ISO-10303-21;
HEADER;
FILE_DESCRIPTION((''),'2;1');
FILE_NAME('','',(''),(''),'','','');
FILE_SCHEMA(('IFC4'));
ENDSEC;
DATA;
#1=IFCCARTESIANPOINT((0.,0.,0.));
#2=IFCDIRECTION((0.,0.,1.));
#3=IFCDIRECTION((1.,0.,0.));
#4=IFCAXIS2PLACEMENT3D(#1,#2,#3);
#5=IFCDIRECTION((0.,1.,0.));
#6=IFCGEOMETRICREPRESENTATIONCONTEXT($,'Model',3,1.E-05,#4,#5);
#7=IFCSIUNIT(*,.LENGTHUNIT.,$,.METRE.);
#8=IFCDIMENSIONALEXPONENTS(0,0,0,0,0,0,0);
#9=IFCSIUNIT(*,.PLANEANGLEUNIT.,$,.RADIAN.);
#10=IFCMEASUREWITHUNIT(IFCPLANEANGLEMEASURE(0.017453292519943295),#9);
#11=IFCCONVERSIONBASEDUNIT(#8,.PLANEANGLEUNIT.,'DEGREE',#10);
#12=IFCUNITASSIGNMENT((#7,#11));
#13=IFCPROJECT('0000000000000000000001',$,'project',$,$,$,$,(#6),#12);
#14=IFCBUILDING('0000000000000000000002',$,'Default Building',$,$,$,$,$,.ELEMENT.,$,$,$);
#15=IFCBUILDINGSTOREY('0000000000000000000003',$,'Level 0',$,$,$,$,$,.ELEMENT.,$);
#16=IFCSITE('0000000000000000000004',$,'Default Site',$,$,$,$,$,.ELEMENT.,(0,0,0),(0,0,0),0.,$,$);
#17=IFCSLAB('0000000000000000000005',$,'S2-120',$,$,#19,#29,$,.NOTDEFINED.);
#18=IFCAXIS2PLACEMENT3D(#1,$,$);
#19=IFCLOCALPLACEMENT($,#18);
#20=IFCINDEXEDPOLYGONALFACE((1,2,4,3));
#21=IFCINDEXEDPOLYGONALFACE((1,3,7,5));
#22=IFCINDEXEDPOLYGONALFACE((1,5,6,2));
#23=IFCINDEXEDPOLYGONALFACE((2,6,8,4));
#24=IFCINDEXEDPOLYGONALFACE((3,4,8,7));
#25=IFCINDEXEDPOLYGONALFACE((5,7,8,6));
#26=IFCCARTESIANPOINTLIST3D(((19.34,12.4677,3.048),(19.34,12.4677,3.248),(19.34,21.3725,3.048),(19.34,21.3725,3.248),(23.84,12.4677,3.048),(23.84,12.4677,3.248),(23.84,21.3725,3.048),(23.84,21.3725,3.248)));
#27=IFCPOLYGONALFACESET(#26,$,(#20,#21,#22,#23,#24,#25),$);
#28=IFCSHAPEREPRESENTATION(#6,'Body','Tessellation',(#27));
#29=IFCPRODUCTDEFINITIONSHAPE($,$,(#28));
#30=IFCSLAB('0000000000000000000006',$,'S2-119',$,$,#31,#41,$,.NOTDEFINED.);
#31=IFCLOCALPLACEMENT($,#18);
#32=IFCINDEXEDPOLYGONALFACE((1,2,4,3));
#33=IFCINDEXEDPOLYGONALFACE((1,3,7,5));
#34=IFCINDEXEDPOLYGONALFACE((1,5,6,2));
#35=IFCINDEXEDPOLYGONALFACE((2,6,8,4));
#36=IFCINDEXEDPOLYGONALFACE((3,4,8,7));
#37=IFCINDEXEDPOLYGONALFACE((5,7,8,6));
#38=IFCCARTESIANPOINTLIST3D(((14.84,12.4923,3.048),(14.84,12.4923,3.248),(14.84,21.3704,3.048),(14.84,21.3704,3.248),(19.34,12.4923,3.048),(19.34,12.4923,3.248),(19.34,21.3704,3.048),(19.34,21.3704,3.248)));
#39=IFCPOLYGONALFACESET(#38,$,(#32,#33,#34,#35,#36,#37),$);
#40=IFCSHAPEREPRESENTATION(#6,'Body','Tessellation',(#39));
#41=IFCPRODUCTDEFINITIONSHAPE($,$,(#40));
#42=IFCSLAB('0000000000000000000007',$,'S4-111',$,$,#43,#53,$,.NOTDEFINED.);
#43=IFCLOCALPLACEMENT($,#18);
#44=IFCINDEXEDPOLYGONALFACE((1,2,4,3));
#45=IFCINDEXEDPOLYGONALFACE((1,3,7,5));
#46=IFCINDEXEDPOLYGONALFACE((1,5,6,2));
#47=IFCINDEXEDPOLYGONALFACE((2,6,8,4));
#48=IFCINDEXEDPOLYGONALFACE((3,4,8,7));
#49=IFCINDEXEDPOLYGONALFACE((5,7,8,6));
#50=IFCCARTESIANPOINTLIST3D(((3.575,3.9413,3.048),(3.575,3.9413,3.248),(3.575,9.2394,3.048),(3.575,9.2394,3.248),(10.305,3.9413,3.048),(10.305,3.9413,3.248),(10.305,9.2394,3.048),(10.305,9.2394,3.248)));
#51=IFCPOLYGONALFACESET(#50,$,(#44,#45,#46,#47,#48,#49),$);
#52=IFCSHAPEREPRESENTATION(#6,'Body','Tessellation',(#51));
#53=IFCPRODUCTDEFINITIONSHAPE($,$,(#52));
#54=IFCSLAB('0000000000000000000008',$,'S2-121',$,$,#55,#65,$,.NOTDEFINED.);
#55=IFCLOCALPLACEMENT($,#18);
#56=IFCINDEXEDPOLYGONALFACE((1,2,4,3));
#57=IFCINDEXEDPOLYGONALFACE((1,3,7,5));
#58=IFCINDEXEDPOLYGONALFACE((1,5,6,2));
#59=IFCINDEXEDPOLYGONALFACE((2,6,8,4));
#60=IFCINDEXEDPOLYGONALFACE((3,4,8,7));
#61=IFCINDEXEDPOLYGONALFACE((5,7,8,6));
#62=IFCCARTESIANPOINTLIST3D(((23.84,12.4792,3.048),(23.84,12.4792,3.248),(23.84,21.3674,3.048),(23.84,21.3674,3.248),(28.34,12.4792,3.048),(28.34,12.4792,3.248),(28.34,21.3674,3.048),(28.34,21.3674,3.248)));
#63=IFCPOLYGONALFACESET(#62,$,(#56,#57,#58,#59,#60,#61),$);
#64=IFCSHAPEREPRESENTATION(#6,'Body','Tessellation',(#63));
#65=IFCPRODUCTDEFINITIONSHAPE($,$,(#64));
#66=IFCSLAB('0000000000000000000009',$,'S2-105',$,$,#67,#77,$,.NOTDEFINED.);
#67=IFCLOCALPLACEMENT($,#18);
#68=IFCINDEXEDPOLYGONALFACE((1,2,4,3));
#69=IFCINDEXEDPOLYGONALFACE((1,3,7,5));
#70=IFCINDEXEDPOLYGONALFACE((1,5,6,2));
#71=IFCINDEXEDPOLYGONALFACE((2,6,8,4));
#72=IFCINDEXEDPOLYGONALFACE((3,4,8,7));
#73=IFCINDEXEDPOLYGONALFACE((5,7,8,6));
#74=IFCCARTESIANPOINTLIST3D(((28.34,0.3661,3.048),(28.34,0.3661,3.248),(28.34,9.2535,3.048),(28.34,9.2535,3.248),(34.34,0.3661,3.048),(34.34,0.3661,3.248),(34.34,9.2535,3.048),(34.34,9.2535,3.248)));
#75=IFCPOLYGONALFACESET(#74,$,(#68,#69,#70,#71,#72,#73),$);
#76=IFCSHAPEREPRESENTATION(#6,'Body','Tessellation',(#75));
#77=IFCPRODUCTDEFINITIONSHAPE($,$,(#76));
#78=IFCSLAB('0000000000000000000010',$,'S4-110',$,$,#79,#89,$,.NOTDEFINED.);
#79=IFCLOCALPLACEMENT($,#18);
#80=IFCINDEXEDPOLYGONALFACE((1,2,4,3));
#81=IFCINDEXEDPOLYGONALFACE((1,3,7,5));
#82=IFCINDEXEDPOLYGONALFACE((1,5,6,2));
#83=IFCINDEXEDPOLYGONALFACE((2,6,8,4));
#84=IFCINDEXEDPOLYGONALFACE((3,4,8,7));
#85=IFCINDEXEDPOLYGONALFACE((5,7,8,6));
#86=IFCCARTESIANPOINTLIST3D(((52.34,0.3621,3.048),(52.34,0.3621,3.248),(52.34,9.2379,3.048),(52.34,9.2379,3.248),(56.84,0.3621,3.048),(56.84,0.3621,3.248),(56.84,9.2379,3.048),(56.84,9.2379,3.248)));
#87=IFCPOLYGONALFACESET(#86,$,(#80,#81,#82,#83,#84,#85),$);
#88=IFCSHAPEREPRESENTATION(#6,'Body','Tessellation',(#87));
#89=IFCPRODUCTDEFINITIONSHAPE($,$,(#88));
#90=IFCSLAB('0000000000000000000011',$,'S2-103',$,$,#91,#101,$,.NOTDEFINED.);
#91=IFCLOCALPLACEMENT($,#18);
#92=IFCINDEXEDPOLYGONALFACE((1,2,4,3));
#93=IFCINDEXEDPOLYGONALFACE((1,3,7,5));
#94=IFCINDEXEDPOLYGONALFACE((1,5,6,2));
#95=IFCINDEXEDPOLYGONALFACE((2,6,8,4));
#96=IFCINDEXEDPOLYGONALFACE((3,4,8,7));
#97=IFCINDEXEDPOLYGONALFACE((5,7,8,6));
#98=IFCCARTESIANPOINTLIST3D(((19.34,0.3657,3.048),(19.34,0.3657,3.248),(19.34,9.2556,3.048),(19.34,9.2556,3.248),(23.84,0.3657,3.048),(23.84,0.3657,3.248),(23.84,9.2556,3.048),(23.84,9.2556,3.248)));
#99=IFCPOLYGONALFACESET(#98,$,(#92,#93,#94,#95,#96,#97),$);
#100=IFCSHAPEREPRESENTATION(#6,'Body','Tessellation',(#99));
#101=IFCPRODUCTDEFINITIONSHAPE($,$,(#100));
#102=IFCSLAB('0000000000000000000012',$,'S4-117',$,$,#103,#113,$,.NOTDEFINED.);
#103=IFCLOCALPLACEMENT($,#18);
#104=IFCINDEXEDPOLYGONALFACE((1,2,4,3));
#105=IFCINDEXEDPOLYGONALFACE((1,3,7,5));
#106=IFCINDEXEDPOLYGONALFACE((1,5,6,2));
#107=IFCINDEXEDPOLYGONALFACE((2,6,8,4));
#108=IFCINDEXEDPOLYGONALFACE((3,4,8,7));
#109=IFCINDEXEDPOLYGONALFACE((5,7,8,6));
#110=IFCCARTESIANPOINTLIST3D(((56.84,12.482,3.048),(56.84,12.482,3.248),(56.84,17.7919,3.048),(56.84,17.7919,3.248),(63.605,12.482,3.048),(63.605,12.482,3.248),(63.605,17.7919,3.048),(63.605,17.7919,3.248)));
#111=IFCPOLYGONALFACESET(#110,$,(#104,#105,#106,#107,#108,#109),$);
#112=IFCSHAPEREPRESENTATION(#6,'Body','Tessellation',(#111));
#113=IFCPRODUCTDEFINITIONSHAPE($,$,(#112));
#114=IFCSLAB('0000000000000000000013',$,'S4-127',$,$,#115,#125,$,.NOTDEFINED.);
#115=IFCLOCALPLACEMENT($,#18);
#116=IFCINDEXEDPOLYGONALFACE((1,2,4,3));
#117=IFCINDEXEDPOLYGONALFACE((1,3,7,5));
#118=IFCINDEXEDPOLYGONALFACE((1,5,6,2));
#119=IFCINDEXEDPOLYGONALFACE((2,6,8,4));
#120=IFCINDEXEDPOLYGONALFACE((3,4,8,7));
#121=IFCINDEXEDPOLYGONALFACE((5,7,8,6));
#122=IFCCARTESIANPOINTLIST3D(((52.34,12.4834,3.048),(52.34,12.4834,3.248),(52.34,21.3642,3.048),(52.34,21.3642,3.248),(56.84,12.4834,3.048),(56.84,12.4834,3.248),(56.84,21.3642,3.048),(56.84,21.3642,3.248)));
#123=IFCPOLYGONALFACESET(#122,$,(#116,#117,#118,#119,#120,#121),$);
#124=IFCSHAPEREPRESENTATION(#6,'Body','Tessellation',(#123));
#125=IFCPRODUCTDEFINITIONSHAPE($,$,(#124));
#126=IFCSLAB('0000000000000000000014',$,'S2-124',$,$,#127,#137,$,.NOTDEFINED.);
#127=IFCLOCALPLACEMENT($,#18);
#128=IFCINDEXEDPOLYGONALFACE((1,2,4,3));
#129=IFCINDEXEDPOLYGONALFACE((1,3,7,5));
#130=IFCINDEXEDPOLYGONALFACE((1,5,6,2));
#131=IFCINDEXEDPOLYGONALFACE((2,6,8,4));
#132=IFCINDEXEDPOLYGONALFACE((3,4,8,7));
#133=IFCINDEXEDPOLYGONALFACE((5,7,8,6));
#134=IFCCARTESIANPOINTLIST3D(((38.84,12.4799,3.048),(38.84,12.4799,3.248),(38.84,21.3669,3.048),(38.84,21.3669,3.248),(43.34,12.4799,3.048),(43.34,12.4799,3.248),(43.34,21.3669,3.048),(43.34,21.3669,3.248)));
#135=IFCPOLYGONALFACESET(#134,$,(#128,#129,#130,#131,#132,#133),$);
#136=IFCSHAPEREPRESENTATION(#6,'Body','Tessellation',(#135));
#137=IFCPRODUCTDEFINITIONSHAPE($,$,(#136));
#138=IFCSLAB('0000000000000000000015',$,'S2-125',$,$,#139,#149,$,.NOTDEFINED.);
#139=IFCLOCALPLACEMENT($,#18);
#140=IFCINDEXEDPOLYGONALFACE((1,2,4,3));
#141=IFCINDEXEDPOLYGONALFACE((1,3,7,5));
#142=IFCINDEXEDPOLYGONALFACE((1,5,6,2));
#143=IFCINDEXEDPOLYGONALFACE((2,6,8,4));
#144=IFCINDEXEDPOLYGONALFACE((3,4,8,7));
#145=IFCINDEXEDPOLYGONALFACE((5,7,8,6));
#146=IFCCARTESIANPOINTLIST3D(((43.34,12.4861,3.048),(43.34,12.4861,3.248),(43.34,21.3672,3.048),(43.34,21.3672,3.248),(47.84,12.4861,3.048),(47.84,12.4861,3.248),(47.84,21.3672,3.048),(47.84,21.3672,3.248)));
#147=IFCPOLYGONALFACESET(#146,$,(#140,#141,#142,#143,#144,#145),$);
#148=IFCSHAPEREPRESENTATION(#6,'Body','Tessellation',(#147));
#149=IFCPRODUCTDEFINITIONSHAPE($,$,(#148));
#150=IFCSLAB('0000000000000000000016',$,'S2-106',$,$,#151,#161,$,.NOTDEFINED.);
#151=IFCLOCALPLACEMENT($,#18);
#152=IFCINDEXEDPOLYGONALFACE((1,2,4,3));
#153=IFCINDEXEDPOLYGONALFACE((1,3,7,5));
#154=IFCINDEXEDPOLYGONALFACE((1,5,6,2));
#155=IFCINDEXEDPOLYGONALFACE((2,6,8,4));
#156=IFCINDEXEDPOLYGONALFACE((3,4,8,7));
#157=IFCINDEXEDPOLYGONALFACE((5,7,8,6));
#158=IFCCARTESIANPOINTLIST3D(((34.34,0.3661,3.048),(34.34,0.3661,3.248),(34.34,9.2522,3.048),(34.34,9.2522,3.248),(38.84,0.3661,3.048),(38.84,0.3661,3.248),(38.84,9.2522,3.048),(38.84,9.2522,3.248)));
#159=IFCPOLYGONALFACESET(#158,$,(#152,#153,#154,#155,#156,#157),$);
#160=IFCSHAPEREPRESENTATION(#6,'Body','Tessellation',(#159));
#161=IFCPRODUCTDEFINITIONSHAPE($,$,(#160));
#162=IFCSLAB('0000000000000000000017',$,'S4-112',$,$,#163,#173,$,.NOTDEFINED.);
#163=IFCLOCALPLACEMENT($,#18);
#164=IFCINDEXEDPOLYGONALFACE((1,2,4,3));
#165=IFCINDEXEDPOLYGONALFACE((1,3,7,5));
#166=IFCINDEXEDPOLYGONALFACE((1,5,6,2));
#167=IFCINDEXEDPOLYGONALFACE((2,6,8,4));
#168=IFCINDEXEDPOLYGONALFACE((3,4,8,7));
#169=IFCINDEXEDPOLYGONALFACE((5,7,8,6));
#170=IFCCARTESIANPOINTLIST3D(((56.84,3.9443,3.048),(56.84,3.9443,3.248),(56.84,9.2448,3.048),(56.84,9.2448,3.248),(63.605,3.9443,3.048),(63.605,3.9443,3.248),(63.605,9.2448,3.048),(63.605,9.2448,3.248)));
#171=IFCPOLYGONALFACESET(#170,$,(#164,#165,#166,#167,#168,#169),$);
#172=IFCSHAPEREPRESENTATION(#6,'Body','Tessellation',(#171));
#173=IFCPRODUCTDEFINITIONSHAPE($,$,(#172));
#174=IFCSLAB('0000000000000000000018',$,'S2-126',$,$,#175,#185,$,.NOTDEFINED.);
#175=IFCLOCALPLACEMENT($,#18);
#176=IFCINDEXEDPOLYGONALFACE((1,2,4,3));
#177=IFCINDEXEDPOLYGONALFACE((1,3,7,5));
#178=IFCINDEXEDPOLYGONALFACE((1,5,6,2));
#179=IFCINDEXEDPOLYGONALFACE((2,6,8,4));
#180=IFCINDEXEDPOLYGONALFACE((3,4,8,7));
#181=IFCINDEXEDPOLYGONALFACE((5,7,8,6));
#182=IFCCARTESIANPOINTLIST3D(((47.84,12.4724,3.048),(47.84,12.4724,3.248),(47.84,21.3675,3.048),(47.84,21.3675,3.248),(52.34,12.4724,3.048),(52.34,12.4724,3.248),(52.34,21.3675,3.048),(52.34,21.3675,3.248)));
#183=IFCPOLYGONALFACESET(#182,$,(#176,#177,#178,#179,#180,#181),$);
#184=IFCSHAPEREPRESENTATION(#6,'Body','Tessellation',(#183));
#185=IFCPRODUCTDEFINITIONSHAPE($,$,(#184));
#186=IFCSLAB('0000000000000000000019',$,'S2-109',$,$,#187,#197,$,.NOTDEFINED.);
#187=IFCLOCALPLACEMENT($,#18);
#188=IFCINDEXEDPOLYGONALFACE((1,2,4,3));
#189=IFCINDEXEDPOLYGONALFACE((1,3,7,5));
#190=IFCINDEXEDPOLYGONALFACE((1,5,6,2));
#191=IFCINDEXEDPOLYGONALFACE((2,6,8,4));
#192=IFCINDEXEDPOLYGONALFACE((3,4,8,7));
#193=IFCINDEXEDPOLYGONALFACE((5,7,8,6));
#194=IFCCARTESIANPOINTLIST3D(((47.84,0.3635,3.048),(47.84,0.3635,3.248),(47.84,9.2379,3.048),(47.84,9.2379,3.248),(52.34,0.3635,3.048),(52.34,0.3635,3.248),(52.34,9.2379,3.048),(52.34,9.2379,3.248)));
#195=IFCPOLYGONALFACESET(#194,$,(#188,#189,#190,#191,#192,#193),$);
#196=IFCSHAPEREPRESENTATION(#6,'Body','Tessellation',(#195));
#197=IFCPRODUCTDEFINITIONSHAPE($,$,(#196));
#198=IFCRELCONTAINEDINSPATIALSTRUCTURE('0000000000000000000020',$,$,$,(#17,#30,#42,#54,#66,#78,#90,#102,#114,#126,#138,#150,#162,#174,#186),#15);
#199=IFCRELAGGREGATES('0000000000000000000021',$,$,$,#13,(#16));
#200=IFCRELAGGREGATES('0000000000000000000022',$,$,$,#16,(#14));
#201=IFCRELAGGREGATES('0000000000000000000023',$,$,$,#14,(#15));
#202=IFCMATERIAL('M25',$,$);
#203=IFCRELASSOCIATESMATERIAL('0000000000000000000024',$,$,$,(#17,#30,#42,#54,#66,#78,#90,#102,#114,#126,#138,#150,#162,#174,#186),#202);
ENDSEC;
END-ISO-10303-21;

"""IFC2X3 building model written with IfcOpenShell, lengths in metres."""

from ifc_helpers import new_model, entity, si_unit, converted_unit, direction, frame, frame_2d, origin_with_axes, place, context, project, spatial, rectangle, extrude, material, element, save


model = new_model("IFC2X3")

# Units and contexts
model_context = context("Model", 3, precision=1e-05, world=origin_with_axes(), true_north=direction((0.0, 1.0, 0.0)))
ifc_project = project(units=[si_unit("LENGTHUNIT", "METRE"), converted_unit("PLANEANGLEUNIT", "DEGREE", entity("IfcPlaneAngleMeasure", 0.017453292519943295), si_unit("PLANEANGLEUNIT", "RADIAN"), dimensions=[0, 0, 0, 0, 0, 0, 0])], contexts=[model_context])

# Site, building, storey
site = spatial("IfcSite", under=ifc_project, Name="Default Site", CompositionType="ELEMENT", RefLatitude=(0, 0, 0), RefLongitude=(0, 0, 0), RefElevation=0.0)
building = spatial("IfcBuilding", under=site, Name="Default Building", CompositionType="ELEMENT")
storey = spatial("IfcBuildingStorey", under=building, Name="Level 0", CompositionType="ELEMENT")

# Shared definitions
ifc_material = material(Name="M25")
placement = place(None, origin_with_axes())

# Slabs
element("IfcSlab", 1, at=placement, inside=storey, material=ifc_material, Name="S2-120", PredefinedType="NOTDEFINED", context=model_context, shape_type="SweptSolid", body=[
    extrude(rectangle(XDim=4.5, YDim=8.9048, at=frame_2d((0.0, 0.0), x_axis=(1.0, 0.0, 0.0))), frame((21.59, 16.9201, 3.048), z_axis=(0.0, 0.0, 1.0), x_axis=(1.0, 0.0, 0.0)), (0.0, 0.0, 1.0), 0.2),
])
element("IfcSlab", 2, at=placement, inside=storey, material=ifc_material, Name="S2-119", PredefinedType="NOTDEFINED", context=model_context, shape_type="SweptSolid", body=[
    extrude(rectangle(XDim=4.5, YDim=8.8781, at=frame_2d((0.0, 0.0), x_axis=(1.0, 0.0, 0.0))), frame((17.09, 16.9313, 3.048), z_axis=(0.0, 0.0, 1.0), x_axis=(1.0, 0.0, 0.0)), (0.0, 0.0, 1.0), 0.2),
])
element("IfcSlab", 3, at=placement, inside=storey, material=ifc_material, Name="S4-111", PredefinedType="NOTDEFINED", context=model_context, shape_type="SweptSolid", body=[
    extrude(rectangle(XDim=6.73, YDim=5.2982, at=frame_2d((0.0, 0.0), x_axis=(1.0, 0.0, 0.0))), frame((6.94, 6.5903, 3.048), z_axis=(0.0, 0.0, 1.0), x_axis=(1.0, 0.0, 0.0)), (0.0, 0.0, 1.0), 0.2),
])
element("IfcSlab", 4, at=placement, inside=storey, material=ifc_material, Name="S2-121", PredefinedType="NOTDEFINED", context=model_context, shape_type="SweptSolid", body=[
    extrude(rectangle(XDim=4.5, YDim=8.8882, at=frame_2d((0.0, 0.0), x_axis=(1.0, 0.0, 0.0))), frame((26.09, 16.9233, 3.048), z_axis=(0.0, 0.0, 1.0), x_axis=(1.0, 0.0, 0.0)), (0.0, 0.0, 1.0), 0.2),
])
element("IfcSlab", 5, at=placement, inside=storey, material=ifc_material, Name="S2-105", PredefinedType="NOTDEFINED", context=model_context, shape_type="SweptSolid", body=[
    extrude(rectangle(XDim=6.0, YDim=8.8874, at=frame_2d((0.0, 0.0), x_axis=(1.0, 0.0, 0.0))), frame((31.34, 4.8098, 3.048), z_axis=(0.0, 0.0, 1.0), x_axis=(1.0, 0.0, 0.0)), (0.0, 0.0, 1.0), 0.2),
])
element("IfcSlab", 6, at=placement, inside=storey, material=ifc_material, Name="S4-110", PredefinedType="NOTDEFINED", context=model_context, shape_type="SweptSolid", body=[
    extrude(rectangle(XDim=4.5, YDim=8.8758, at=frame_2d((0.0, 0.0), x_axis=(1.0, 0.0, 0.0))), frame((54.59, 4.8, 3.048), z_axis=(0.0, 0.0, 1.0), x_axis=(1.0, 0.0, 0.0)), (0.0, 0.0, 1.0), 0.2),
])
element("IfcSlab", 7, at=placement, inside=storey, material=ifc_material, Name="S2-103", PredefinedType="NOTDEFINED", context=model_context, shape_type="SweptSolid", body=[
    extrude(rectangle(XDim=4.5, YDim=8.89, at=frame_2d((0.0, 0.0), x_axis=(1.0, 0.0, 0.0))), frame((21.59, 4.8106, 3.048), z_axis=(0.0, 0.0, 1.0), x_axis=(1.0, 0.0, 0.0)), (0.0, 0.0, 1.0), 0.2),
])
element("IfcSlab", 8, at=placement, inside=storey, material=ifc_material, Name="S4-117", PredefinedType="NOTDEFINED", context=model_context, shape_type="SweptSolid", body=[
    extrude(rectangle(XDim=6.765, YDim=5.3099, at=frame_2d((0.0, 0.0), x_axis=(1.0, 0.0, 0.0))), frame((60.2225, 15.1369, 3.048), z_axis=(0.0, 0.0, 1.0), x_axis=(1.0, 0.0, 0.0)), (0.0, 0.0, 1.0), 0.2),
])
element("IfcSlab", 9, at=placement, inside=storey, material=ifc_material, Name="S4-127", PredefinedType="NOTDEFINED", context=model_context, shape_type="SweptSolid", body=[
    extrude(rectangle(XDim=4.5, YDim=8.8807, at=frame_2d((0.0, 0.0), x_axis=(1.0, 0.0, 0.0))), frame((54.59, 16.9238, 3.048), z_axis=(0.0, 0.0, 1.0), x_axis=(1.0, 0.0, 0.0)), (0.0, 0.0, 1.0), 0.2),
])
element("IfcSlab", 10, at=placement, inside=storey, material=ifc_material, Name="S2-124", PredefinedType="NOTDEFINED", context=model_context, shape_type="SweptSolid", body=[
    extrude(rectangle(XDim=4.5, YDim=8.8871, at=frame_2d((0.0, 0.0), x_axis=(1.0, 0.0, 0.0))), frame((41.09, 16.9234, 3.048), z_axis=(0.0, 0.0, 1.0), x_axis=(1.0, 0.0, 0.0)), (0.0, 0.0, 1.0), 0.2),
])
element("IfcSlab", 11, at=placement, inside=storey, material=ifc_material, Name="S2-125", PredefinedType="NOTDEFINED", context=model_context, shape_type="SweptSolid", body=[
    extrude(rectangle(XDim=4.5, YDim=8.8811, at=frame_2d((0.0, 0.0), x_axis=(1.0, 0.0, 0.0))), frame((45.59, 16.9266, 3.048), z_axis=(0.0, 0.0, 1.0), x_axis=(1.0, 0.0, 0.0)), (0.0, 0.0, 1.0), 0.2),
])
element("IfcSlab", 12, at=placement, inside=storey, material=ifc_material, Name="S2-106", PredefinedType="NOTDEFINED", context=model_context, shape_type="SweptSolid", body=[
    extrude(rectangle(XDim=4.5, YDim=8.8861, at=frame_2d((0.0, 0.0), x_axis=(1.0, 0.0, 0.0))), frame((36.59, 4.8092, 3.048), z_axis=(0.0, 0.0, 1.0), x_axis=(1.0, 0.0, 0.0)), (0.0, 0.0, 1.0), 0.2),
])
element("IfcSlab", 13, at=placement, inside=storey, material=ifc_material, Name="S4-112", PredefinedType="NOTDEFINED", context=model_context, shape_type="SweptSolid", body=[
    extrude(rectangle(XDim=6.765, YDim=5.3005, at=frame_2d((0.0, 0.0), x_axis=(1.0, 0.0, 0.0))), frame((60.2225, 6.5946, 3.048), z_axis=(0.0, 0.0, 1.0), x_axis=(1.0, 0.0, 0.0)), (0.0, 0.0, 1.0), 0.2),
])
element("IfcSlab", 14, at=placement, inside=storey, material=ifc_material, Name="S2-126", PredefinedType="NOTDEFINED", context=model_context, shape_type="SweptSolid", body=[
    extrude(rectangle(XDim=4.5, YDim=8.8951, at=frame_2d((0.0, 0.0), x_axis=(1.0, 0.0, 0.0))), frame((50.09, 16.9199, 3.048), z_axis=(0.0, 0.0, 1.0), x_axis=(1.0, 0.0, 0.0)), (0.0, 0.0, 1.0), 0.2),
])
element("IfcSlab", 15, at=placement, inside=storey, material=ifc_material, Name="S2-109", PredefinedType="NOTDEFINED", context=model_context, shape_type="SweptSolid", body=[
    extrude(rectangle(XDim=4.5, YDim=8.8744, at=frame_2d((0.0, 0.0), x_axis=(1.0, 0.0, 0.0))), frame((50.09, 4.8007, 3.048), z_axis=(0.0, 0.0, 1.0), x_axis=(1.0, 0.0, 0.0)), (0.0, 0.0, 1.0), 0.2),
])

save(model, "model.ifc")
